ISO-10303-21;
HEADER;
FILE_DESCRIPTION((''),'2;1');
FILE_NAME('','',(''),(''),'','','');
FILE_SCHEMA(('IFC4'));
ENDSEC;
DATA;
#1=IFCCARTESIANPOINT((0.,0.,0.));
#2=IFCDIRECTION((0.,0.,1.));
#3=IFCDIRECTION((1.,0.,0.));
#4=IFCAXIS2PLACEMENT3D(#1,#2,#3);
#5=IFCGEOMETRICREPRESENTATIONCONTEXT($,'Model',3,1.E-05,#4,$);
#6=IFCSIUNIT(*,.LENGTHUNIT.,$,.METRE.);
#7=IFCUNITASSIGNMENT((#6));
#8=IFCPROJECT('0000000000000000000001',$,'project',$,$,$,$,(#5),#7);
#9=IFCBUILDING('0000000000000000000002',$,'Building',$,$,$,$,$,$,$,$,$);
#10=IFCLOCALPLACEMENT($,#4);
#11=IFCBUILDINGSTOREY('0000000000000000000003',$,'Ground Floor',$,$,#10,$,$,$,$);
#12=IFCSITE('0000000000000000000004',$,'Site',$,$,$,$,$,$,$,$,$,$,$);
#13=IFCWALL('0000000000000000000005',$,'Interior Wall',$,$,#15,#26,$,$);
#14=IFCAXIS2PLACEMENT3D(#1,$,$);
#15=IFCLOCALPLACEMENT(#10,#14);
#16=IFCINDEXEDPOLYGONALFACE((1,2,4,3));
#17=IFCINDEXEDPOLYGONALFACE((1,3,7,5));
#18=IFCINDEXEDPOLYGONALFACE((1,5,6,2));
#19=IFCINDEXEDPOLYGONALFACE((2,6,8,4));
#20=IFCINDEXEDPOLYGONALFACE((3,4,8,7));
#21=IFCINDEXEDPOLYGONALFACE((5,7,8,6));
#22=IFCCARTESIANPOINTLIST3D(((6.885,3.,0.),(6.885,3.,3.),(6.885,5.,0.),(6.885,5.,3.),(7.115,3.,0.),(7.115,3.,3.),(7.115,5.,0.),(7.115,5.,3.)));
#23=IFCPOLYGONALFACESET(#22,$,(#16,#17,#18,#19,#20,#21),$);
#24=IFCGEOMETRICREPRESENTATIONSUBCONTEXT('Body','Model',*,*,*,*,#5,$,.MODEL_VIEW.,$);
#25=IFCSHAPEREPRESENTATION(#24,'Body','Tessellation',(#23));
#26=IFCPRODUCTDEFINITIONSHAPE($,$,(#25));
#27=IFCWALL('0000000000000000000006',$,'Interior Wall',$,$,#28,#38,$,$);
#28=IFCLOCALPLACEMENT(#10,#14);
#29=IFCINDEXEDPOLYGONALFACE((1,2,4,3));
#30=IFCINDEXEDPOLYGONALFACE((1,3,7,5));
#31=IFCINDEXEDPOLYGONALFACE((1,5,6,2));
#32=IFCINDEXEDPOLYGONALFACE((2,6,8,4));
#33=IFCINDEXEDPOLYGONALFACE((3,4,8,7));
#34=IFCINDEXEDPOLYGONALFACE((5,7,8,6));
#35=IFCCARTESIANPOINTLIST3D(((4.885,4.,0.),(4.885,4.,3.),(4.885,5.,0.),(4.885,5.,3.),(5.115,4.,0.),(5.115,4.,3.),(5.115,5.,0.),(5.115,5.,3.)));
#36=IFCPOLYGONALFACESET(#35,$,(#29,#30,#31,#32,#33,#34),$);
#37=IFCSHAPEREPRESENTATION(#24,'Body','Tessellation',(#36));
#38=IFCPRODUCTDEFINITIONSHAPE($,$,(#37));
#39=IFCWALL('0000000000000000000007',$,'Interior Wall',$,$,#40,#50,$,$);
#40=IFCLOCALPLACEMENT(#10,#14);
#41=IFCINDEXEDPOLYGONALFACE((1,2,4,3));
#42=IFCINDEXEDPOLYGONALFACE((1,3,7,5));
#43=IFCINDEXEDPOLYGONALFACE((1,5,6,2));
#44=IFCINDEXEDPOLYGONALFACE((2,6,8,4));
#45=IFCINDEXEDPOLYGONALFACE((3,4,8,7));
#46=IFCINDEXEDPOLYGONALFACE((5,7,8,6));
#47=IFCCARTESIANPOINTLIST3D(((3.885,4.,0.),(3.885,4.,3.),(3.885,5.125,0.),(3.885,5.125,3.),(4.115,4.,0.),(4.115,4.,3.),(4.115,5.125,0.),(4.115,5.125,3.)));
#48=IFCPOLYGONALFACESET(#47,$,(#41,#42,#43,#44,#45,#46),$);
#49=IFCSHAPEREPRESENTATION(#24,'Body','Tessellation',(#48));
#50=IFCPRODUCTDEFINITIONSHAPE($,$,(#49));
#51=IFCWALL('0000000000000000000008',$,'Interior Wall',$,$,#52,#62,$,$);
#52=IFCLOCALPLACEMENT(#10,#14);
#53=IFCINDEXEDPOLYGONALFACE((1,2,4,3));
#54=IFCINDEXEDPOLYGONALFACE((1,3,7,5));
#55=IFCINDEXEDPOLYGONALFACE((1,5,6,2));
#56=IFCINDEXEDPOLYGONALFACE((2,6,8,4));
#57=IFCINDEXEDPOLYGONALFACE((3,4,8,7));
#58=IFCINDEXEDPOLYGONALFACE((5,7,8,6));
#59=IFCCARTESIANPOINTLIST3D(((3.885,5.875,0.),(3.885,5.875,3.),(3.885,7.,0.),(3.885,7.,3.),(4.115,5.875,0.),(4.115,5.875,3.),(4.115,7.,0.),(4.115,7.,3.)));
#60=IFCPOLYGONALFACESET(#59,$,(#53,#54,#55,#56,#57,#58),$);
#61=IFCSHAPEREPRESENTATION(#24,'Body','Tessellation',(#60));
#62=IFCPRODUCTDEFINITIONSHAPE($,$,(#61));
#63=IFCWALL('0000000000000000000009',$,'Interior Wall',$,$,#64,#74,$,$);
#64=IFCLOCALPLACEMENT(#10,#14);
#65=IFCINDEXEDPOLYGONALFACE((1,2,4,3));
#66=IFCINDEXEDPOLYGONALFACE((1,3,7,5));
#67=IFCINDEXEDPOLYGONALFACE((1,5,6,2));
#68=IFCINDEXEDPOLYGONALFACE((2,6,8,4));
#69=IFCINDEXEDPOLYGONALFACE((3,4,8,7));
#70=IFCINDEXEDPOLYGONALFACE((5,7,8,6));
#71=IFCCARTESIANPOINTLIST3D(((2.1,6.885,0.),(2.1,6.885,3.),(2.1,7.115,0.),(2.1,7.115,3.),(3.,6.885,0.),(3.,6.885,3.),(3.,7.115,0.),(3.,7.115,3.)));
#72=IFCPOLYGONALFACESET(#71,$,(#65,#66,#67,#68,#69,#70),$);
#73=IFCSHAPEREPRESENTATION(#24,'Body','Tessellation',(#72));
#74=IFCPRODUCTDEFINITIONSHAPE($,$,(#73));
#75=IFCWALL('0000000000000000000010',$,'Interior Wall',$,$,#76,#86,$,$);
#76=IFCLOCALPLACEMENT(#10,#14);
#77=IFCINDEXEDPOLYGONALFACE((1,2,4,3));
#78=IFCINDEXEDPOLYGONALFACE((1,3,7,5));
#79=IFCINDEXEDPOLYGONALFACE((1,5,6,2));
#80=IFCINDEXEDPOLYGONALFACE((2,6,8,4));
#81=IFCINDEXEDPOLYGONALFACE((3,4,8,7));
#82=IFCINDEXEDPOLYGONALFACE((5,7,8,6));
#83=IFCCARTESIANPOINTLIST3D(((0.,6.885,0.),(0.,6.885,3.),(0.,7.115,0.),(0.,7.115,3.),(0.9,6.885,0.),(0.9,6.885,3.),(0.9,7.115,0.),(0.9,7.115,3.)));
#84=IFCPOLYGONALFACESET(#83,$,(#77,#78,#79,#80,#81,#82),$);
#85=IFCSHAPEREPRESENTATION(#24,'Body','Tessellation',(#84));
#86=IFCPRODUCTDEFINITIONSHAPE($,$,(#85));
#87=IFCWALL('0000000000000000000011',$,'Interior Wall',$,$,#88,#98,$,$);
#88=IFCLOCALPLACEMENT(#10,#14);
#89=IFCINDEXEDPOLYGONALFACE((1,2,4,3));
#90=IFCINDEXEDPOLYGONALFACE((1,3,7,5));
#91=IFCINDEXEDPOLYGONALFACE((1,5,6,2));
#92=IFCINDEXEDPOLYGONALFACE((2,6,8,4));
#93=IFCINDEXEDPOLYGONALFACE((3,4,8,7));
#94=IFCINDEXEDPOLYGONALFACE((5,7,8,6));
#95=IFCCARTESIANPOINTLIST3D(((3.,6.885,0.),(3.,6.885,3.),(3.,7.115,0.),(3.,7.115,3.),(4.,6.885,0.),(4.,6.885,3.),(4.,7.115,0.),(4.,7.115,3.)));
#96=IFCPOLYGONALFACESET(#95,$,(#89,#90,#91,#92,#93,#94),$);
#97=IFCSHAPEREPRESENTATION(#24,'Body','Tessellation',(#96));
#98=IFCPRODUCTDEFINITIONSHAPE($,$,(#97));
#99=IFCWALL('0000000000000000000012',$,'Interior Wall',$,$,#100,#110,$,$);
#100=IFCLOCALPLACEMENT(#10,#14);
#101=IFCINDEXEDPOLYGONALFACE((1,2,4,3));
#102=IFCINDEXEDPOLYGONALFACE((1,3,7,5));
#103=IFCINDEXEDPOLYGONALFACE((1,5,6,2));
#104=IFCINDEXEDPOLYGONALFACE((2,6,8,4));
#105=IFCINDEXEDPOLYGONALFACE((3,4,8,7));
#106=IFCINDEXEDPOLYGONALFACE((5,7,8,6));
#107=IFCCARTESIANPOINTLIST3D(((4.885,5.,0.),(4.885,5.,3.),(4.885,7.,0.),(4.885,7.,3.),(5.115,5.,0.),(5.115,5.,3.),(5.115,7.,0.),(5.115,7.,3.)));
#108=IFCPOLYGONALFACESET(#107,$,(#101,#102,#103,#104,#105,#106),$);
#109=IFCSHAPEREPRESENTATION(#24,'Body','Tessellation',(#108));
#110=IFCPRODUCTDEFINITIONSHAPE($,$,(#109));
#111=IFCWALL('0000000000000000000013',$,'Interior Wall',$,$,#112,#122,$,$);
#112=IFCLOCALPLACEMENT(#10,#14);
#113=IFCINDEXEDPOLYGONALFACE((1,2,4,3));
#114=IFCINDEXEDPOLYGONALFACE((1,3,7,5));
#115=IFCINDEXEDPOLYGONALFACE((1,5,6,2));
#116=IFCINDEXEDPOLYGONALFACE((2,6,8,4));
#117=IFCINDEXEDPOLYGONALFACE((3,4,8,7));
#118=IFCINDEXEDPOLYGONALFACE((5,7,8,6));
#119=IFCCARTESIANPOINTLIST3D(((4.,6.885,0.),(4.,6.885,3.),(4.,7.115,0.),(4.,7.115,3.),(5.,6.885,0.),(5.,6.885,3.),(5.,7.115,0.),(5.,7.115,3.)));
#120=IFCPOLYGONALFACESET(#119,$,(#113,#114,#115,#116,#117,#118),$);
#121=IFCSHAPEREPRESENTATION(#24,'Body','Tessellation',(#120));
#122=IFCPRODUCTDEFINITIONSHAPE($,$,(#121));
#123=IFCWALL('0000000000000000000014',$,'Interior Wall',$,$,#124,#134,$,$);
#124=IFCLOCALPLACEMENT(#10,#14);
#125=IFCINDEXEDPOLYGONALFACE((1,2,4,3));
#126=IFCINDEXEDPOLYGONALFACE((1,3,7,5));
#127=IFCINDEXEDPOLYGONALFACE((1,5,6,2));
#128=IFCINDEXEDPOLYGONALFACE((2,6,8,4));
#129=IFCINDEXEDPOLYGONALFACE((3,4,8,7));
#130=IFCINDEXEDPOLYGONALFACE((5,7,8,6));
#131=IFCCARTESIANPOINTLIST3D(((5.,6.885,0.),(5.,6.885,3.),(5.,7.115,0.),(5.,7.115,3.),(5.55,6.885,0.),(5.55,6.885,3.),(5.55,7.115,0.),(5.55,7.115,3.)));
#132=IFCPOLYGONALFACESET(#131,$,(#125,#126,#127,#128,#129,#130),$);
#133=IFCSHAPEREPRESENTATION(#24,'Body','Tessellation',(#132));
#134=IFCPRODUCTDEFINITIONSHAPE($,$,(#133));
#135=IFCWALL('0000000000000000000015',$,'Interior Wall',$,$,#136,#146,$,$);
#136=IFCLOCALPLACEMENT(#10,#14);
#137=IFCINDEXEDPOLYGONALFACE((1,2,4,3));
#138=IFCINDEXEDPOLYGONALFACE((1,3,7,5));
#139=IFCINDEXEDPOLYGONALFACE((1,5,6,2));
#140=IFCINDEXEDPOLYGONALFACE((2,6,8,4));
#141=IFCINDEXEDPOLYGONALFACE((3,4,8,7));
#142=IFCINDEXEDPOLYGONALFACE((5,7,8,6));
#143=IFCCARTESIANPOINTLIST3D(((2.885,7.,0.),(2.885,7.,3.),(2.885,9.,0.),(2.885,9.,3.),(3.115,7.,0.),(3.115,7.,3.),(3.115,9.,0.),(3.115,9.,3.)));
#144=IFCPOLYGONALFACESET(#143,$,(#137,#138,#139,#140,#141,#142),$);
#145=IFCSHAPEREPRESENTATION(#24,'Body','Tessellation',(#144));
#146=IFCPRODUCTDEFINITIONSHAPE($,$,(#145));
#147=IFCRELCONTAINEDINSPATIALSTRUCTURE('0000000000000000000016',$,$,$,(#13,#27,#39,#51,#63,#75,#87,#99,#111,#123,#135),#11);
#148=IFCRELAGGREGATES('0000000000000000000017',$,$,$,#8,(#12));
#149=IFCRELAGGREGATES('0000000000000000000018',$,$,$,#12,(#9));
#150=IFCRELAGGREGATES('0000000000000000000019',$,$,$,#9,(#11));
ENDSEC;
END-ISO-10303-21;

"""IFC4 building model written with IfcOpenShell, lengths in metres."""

from ifc_helpers import new_model, si_unit, frame, origin_with_axes, place, context, subcontext, project, spatial, indexed_curve, outline, extrude, element, save


model = new_model("IFC4")

# Units and contexts
model_context = context("Model", 3, precision=1e-05, world=origin_with_axes())
body_context = subcontext(model_context, "Body", "Model", "MODEL_VIEW")
ifc_project = project(units=[si_unit("LENGTHUNIT", "METRE")], contexts=[model_context])

# Site, building, storey
site = spatial("IfcSite", under=ifc_project, Name="Site")
building = spatial("IfcBuilding", under=site, Name="Building")
storey_placement = place(None, origin_with_axes())
storey = spatial("IfcBuildingStorey", under=building, at=storey_placement, Name="Ground Floor")

# Walls
wall_1_placement = place(storey_placement, frame((7.0, 3.0, 0.0), z_axis=(0.0, 0.0, 1.0), x_axis=(0.0, 1.0, 0.0)))
element("IfcWall", 1, at=wall_1_placement, inside=storey, Name="Interior Wall", context=body_context, shape_type="SweptSolid", body=[
    extrude(outline(indexed_curve([(0.0, 0.0), (0.0, 0.23), (2.0, 0.23), (2.0, 0.0), (0.0, 0.0)], self_intersect=False)), frame((0.0, -0.115, 0.0), z_axis=(0.0, 0.0, 1.0), x_axis=(1.0, 0.0, 0.0)), (0.0, 0.0, 1.0), 3.0),
])
wall_2_placement = place(storey_placement, frame((5.0, 5.0, 0.0), z_axis=(0.0, 0.0, 1.0), x_axis=(0.0, -1.0, 0.0)))
element("IfcWall", 2, at=wall_2_placement, inside=storey, Name="Interior Wall", context=body_context, shape_type="SweptSolid", body=[
    extrude(outline(indexed_curve([(0.0, 0.0), (0.0, 0.23), (1.0, 0.23), (1.0, 0.0), (0.0, 0.0)], self_intersect=False)), frame((0.0, -0.115, 0.0), z_axis=(0.0, 0.0, 1.0), x_axis=(1.0, 0.0, 0.0)), (0.0, 0.0, 1.0), 3.0),
])
for number, where, z_axis, x_axis, name in (
    (3, (4.0, 4.0, 0.0), (0.0, 0.0, 1.0), (0.0, 1.0, 0.0), "Interior Wall"),
    (4, (4.0, 5.875, 0.0), (0.0, 0.0, 1.0), (0.0, 1.0, 0.0), "Interior Wall"),
):
    element("IfcWall", number, at=place(storey_placement, frame(where, z_axis=z_axis, x_axis=x_axis)), inside=storey, Name=name, context=body_context, shape_type="SweptSolid", body=[
        extrude(outline(indexed_curve([(0.0, 0.0), (0.0, 0.23), (1.125, 0.23), (1.125, 0.0), (0.0, 0.0)], self_intersect=False)), frame((0.0, -0.115, 0.0), z_axis=(0.0, 0.0, 1.0), x_axis=(1.0, 0.0, 0.0)), (0.0, 0.0, 1.0), 3.0),
    ])
for number, where, z_axis, x_axis, name in (
    (5, (3.0, 7.0, 0.0), (0.0, 0.0, 1.0), (-1.0, 0.0, 0.0), "Interior Wall"),
    (6, (0.9, 7.0, 0.0), (0.0, 0.0, 1.0), (-1.0, 0.0, 0.0), "Interior Wall"),
):
    element("IfcWall", number, at=place(storey_placement, frame(where, z_axis=z_axis, x_axis=x_axis)), inside=storey, Name=name, context=body_context, shape_type="SweptSolid", body=[
        extrude(outline(indexed_curve([(0.0, 0.0), (0.0, 0.23), (0.9, 0.23), (0.9, 0.0), (0.0, 0.0)], self_intersect=False)), frame((0.0, -0.115, 0.0), z_axis=(0.0, 0.0, 1.0), x_axis=(1.0, 0.0, 0.0)), (0.0, 0.0, 1.0), 3.0),
    ])
wall_3_placement = place(storey_placement, frame((4.0, 7.0, 0.0), z_axis=(0.0, 0.0, 1.0), x_axis=(-1.0, 0.0, 0.0)))
element("IfcWall", 7, at=wall_3_placement, inside=storey, Name="Interior Wall", context=body_context, shape_type="SweptSolid", body=[
    extrude(outline(indexed_curve([(0.0, 0.0), (0.0, 0.23), (1.0, 0.23), (1.0, 0.0), (0.0, 0.0)], self_intersect=False)), frame((0.0, -0.115, 0.0), z_axis=(0.0, 0.0, 1.0), x_axis=(1.0, 0.0, 0.0)), (0.0, 0.0, 1.0), 3.0),
])
wall_4_placement = place(storey_placement, frame((5.0, 5.0, 0.0), z_axis=(0.0, 0.0, 1.0), x_axis=(0.0, 1.0, 0.0)))
element("IfcWall", 8, at=wall_4_placement, inside=storey, Name="Interior Wall", context=body_context, shape_type="SweptSolid", body=[
    extrude(outline(indexed_curve([(0.0, 0.0), (0.0, 0.23), (2.0, 0.23), (2.0, 0.0), (0.0, 0.0)], self_intersect=False)), frame((0.0, -0.115, 0.0), z_axis=(0.0, 0.0, 1.0), x_axis=(1.0, 0.0, 0.0)), (0.0, 0.0, 1.0), 3.0),
])
wall_5_placement = place(storey_placement, frame((5.0, 7.0, 0.0), z_axis=(0.0, 0.0, 1.0), x_axis=(-1.0, 0.0, 0.0)))
element("IfcWall", 9, at=wall_5_placement, inside=storey, Name="Interior Wall", context=body_context, shape_type="SweptSolid", body=[
    extrude(outline(indexed_curve([(0.0, 0.0), (0.0, 0.23), (1.0, 0.23), (1.0, 0.0), (0.0, 0.0)], self_intersect=False)), frame((0.0, -0.115, 0.0), z_axis=(0.0, 0.0, 1.0), x_axis=(1.0, 0.0, 0.0)), (0.0, 0.0, 1.0), 3.0),
])
wall_6_placement = place(storey_placement, frame((5.55, 7.0, 0.0), z_axis=(0.0, 0.0, 1.0), x_axis=(-1.0, 0.0, 0.0)))
element("IfcWall", 10, at=wall_6_placement, inside=storey, Name="Interior Wall", context=body_context, shape_type="SweptSolid", body=[
    extrude(outline(indexed_curve([(0.0, 0.0), (0.0, 0.23), (0.55, 0.23), (0.55, 0.0), (0.0, 0.0)], self_intersect=False)), frame((0.0, -0.115, 0.0), z_axis=(0.0, 0.0, 1.0), x_axis=(1.0, 0.0, 0.0)), (0.0, 0.0, 1.0), 3.0),
])
wall_7_placement = place(storey_placement, frame((3.0, 7.0, 0.0), z_axis=(0.0, 0.0, 1.0), x_axis=(0.0, 1.0, 0.0)))
element("IfcWall", 11, at=wall_7_placement, inside=storey, Name="Interior Wall", context=body_context, shape_type="SweptSolid", body=[
    extrude(outline(indexed_curve([(0.0, 0.0), (0.0, 0.23), (2.0, 0.23), (2.0, 0.0), (0.0, 0.0)], self_intersect=False)), frame((0.0, -0.115, 0.0), z_axis=(0.0, 0.0, 1.0), x_axis=(1.0, 0.0, 0.0)), (0.0, 0.0, 1.0), 3.0),
])

save(model, "model.ifc")
